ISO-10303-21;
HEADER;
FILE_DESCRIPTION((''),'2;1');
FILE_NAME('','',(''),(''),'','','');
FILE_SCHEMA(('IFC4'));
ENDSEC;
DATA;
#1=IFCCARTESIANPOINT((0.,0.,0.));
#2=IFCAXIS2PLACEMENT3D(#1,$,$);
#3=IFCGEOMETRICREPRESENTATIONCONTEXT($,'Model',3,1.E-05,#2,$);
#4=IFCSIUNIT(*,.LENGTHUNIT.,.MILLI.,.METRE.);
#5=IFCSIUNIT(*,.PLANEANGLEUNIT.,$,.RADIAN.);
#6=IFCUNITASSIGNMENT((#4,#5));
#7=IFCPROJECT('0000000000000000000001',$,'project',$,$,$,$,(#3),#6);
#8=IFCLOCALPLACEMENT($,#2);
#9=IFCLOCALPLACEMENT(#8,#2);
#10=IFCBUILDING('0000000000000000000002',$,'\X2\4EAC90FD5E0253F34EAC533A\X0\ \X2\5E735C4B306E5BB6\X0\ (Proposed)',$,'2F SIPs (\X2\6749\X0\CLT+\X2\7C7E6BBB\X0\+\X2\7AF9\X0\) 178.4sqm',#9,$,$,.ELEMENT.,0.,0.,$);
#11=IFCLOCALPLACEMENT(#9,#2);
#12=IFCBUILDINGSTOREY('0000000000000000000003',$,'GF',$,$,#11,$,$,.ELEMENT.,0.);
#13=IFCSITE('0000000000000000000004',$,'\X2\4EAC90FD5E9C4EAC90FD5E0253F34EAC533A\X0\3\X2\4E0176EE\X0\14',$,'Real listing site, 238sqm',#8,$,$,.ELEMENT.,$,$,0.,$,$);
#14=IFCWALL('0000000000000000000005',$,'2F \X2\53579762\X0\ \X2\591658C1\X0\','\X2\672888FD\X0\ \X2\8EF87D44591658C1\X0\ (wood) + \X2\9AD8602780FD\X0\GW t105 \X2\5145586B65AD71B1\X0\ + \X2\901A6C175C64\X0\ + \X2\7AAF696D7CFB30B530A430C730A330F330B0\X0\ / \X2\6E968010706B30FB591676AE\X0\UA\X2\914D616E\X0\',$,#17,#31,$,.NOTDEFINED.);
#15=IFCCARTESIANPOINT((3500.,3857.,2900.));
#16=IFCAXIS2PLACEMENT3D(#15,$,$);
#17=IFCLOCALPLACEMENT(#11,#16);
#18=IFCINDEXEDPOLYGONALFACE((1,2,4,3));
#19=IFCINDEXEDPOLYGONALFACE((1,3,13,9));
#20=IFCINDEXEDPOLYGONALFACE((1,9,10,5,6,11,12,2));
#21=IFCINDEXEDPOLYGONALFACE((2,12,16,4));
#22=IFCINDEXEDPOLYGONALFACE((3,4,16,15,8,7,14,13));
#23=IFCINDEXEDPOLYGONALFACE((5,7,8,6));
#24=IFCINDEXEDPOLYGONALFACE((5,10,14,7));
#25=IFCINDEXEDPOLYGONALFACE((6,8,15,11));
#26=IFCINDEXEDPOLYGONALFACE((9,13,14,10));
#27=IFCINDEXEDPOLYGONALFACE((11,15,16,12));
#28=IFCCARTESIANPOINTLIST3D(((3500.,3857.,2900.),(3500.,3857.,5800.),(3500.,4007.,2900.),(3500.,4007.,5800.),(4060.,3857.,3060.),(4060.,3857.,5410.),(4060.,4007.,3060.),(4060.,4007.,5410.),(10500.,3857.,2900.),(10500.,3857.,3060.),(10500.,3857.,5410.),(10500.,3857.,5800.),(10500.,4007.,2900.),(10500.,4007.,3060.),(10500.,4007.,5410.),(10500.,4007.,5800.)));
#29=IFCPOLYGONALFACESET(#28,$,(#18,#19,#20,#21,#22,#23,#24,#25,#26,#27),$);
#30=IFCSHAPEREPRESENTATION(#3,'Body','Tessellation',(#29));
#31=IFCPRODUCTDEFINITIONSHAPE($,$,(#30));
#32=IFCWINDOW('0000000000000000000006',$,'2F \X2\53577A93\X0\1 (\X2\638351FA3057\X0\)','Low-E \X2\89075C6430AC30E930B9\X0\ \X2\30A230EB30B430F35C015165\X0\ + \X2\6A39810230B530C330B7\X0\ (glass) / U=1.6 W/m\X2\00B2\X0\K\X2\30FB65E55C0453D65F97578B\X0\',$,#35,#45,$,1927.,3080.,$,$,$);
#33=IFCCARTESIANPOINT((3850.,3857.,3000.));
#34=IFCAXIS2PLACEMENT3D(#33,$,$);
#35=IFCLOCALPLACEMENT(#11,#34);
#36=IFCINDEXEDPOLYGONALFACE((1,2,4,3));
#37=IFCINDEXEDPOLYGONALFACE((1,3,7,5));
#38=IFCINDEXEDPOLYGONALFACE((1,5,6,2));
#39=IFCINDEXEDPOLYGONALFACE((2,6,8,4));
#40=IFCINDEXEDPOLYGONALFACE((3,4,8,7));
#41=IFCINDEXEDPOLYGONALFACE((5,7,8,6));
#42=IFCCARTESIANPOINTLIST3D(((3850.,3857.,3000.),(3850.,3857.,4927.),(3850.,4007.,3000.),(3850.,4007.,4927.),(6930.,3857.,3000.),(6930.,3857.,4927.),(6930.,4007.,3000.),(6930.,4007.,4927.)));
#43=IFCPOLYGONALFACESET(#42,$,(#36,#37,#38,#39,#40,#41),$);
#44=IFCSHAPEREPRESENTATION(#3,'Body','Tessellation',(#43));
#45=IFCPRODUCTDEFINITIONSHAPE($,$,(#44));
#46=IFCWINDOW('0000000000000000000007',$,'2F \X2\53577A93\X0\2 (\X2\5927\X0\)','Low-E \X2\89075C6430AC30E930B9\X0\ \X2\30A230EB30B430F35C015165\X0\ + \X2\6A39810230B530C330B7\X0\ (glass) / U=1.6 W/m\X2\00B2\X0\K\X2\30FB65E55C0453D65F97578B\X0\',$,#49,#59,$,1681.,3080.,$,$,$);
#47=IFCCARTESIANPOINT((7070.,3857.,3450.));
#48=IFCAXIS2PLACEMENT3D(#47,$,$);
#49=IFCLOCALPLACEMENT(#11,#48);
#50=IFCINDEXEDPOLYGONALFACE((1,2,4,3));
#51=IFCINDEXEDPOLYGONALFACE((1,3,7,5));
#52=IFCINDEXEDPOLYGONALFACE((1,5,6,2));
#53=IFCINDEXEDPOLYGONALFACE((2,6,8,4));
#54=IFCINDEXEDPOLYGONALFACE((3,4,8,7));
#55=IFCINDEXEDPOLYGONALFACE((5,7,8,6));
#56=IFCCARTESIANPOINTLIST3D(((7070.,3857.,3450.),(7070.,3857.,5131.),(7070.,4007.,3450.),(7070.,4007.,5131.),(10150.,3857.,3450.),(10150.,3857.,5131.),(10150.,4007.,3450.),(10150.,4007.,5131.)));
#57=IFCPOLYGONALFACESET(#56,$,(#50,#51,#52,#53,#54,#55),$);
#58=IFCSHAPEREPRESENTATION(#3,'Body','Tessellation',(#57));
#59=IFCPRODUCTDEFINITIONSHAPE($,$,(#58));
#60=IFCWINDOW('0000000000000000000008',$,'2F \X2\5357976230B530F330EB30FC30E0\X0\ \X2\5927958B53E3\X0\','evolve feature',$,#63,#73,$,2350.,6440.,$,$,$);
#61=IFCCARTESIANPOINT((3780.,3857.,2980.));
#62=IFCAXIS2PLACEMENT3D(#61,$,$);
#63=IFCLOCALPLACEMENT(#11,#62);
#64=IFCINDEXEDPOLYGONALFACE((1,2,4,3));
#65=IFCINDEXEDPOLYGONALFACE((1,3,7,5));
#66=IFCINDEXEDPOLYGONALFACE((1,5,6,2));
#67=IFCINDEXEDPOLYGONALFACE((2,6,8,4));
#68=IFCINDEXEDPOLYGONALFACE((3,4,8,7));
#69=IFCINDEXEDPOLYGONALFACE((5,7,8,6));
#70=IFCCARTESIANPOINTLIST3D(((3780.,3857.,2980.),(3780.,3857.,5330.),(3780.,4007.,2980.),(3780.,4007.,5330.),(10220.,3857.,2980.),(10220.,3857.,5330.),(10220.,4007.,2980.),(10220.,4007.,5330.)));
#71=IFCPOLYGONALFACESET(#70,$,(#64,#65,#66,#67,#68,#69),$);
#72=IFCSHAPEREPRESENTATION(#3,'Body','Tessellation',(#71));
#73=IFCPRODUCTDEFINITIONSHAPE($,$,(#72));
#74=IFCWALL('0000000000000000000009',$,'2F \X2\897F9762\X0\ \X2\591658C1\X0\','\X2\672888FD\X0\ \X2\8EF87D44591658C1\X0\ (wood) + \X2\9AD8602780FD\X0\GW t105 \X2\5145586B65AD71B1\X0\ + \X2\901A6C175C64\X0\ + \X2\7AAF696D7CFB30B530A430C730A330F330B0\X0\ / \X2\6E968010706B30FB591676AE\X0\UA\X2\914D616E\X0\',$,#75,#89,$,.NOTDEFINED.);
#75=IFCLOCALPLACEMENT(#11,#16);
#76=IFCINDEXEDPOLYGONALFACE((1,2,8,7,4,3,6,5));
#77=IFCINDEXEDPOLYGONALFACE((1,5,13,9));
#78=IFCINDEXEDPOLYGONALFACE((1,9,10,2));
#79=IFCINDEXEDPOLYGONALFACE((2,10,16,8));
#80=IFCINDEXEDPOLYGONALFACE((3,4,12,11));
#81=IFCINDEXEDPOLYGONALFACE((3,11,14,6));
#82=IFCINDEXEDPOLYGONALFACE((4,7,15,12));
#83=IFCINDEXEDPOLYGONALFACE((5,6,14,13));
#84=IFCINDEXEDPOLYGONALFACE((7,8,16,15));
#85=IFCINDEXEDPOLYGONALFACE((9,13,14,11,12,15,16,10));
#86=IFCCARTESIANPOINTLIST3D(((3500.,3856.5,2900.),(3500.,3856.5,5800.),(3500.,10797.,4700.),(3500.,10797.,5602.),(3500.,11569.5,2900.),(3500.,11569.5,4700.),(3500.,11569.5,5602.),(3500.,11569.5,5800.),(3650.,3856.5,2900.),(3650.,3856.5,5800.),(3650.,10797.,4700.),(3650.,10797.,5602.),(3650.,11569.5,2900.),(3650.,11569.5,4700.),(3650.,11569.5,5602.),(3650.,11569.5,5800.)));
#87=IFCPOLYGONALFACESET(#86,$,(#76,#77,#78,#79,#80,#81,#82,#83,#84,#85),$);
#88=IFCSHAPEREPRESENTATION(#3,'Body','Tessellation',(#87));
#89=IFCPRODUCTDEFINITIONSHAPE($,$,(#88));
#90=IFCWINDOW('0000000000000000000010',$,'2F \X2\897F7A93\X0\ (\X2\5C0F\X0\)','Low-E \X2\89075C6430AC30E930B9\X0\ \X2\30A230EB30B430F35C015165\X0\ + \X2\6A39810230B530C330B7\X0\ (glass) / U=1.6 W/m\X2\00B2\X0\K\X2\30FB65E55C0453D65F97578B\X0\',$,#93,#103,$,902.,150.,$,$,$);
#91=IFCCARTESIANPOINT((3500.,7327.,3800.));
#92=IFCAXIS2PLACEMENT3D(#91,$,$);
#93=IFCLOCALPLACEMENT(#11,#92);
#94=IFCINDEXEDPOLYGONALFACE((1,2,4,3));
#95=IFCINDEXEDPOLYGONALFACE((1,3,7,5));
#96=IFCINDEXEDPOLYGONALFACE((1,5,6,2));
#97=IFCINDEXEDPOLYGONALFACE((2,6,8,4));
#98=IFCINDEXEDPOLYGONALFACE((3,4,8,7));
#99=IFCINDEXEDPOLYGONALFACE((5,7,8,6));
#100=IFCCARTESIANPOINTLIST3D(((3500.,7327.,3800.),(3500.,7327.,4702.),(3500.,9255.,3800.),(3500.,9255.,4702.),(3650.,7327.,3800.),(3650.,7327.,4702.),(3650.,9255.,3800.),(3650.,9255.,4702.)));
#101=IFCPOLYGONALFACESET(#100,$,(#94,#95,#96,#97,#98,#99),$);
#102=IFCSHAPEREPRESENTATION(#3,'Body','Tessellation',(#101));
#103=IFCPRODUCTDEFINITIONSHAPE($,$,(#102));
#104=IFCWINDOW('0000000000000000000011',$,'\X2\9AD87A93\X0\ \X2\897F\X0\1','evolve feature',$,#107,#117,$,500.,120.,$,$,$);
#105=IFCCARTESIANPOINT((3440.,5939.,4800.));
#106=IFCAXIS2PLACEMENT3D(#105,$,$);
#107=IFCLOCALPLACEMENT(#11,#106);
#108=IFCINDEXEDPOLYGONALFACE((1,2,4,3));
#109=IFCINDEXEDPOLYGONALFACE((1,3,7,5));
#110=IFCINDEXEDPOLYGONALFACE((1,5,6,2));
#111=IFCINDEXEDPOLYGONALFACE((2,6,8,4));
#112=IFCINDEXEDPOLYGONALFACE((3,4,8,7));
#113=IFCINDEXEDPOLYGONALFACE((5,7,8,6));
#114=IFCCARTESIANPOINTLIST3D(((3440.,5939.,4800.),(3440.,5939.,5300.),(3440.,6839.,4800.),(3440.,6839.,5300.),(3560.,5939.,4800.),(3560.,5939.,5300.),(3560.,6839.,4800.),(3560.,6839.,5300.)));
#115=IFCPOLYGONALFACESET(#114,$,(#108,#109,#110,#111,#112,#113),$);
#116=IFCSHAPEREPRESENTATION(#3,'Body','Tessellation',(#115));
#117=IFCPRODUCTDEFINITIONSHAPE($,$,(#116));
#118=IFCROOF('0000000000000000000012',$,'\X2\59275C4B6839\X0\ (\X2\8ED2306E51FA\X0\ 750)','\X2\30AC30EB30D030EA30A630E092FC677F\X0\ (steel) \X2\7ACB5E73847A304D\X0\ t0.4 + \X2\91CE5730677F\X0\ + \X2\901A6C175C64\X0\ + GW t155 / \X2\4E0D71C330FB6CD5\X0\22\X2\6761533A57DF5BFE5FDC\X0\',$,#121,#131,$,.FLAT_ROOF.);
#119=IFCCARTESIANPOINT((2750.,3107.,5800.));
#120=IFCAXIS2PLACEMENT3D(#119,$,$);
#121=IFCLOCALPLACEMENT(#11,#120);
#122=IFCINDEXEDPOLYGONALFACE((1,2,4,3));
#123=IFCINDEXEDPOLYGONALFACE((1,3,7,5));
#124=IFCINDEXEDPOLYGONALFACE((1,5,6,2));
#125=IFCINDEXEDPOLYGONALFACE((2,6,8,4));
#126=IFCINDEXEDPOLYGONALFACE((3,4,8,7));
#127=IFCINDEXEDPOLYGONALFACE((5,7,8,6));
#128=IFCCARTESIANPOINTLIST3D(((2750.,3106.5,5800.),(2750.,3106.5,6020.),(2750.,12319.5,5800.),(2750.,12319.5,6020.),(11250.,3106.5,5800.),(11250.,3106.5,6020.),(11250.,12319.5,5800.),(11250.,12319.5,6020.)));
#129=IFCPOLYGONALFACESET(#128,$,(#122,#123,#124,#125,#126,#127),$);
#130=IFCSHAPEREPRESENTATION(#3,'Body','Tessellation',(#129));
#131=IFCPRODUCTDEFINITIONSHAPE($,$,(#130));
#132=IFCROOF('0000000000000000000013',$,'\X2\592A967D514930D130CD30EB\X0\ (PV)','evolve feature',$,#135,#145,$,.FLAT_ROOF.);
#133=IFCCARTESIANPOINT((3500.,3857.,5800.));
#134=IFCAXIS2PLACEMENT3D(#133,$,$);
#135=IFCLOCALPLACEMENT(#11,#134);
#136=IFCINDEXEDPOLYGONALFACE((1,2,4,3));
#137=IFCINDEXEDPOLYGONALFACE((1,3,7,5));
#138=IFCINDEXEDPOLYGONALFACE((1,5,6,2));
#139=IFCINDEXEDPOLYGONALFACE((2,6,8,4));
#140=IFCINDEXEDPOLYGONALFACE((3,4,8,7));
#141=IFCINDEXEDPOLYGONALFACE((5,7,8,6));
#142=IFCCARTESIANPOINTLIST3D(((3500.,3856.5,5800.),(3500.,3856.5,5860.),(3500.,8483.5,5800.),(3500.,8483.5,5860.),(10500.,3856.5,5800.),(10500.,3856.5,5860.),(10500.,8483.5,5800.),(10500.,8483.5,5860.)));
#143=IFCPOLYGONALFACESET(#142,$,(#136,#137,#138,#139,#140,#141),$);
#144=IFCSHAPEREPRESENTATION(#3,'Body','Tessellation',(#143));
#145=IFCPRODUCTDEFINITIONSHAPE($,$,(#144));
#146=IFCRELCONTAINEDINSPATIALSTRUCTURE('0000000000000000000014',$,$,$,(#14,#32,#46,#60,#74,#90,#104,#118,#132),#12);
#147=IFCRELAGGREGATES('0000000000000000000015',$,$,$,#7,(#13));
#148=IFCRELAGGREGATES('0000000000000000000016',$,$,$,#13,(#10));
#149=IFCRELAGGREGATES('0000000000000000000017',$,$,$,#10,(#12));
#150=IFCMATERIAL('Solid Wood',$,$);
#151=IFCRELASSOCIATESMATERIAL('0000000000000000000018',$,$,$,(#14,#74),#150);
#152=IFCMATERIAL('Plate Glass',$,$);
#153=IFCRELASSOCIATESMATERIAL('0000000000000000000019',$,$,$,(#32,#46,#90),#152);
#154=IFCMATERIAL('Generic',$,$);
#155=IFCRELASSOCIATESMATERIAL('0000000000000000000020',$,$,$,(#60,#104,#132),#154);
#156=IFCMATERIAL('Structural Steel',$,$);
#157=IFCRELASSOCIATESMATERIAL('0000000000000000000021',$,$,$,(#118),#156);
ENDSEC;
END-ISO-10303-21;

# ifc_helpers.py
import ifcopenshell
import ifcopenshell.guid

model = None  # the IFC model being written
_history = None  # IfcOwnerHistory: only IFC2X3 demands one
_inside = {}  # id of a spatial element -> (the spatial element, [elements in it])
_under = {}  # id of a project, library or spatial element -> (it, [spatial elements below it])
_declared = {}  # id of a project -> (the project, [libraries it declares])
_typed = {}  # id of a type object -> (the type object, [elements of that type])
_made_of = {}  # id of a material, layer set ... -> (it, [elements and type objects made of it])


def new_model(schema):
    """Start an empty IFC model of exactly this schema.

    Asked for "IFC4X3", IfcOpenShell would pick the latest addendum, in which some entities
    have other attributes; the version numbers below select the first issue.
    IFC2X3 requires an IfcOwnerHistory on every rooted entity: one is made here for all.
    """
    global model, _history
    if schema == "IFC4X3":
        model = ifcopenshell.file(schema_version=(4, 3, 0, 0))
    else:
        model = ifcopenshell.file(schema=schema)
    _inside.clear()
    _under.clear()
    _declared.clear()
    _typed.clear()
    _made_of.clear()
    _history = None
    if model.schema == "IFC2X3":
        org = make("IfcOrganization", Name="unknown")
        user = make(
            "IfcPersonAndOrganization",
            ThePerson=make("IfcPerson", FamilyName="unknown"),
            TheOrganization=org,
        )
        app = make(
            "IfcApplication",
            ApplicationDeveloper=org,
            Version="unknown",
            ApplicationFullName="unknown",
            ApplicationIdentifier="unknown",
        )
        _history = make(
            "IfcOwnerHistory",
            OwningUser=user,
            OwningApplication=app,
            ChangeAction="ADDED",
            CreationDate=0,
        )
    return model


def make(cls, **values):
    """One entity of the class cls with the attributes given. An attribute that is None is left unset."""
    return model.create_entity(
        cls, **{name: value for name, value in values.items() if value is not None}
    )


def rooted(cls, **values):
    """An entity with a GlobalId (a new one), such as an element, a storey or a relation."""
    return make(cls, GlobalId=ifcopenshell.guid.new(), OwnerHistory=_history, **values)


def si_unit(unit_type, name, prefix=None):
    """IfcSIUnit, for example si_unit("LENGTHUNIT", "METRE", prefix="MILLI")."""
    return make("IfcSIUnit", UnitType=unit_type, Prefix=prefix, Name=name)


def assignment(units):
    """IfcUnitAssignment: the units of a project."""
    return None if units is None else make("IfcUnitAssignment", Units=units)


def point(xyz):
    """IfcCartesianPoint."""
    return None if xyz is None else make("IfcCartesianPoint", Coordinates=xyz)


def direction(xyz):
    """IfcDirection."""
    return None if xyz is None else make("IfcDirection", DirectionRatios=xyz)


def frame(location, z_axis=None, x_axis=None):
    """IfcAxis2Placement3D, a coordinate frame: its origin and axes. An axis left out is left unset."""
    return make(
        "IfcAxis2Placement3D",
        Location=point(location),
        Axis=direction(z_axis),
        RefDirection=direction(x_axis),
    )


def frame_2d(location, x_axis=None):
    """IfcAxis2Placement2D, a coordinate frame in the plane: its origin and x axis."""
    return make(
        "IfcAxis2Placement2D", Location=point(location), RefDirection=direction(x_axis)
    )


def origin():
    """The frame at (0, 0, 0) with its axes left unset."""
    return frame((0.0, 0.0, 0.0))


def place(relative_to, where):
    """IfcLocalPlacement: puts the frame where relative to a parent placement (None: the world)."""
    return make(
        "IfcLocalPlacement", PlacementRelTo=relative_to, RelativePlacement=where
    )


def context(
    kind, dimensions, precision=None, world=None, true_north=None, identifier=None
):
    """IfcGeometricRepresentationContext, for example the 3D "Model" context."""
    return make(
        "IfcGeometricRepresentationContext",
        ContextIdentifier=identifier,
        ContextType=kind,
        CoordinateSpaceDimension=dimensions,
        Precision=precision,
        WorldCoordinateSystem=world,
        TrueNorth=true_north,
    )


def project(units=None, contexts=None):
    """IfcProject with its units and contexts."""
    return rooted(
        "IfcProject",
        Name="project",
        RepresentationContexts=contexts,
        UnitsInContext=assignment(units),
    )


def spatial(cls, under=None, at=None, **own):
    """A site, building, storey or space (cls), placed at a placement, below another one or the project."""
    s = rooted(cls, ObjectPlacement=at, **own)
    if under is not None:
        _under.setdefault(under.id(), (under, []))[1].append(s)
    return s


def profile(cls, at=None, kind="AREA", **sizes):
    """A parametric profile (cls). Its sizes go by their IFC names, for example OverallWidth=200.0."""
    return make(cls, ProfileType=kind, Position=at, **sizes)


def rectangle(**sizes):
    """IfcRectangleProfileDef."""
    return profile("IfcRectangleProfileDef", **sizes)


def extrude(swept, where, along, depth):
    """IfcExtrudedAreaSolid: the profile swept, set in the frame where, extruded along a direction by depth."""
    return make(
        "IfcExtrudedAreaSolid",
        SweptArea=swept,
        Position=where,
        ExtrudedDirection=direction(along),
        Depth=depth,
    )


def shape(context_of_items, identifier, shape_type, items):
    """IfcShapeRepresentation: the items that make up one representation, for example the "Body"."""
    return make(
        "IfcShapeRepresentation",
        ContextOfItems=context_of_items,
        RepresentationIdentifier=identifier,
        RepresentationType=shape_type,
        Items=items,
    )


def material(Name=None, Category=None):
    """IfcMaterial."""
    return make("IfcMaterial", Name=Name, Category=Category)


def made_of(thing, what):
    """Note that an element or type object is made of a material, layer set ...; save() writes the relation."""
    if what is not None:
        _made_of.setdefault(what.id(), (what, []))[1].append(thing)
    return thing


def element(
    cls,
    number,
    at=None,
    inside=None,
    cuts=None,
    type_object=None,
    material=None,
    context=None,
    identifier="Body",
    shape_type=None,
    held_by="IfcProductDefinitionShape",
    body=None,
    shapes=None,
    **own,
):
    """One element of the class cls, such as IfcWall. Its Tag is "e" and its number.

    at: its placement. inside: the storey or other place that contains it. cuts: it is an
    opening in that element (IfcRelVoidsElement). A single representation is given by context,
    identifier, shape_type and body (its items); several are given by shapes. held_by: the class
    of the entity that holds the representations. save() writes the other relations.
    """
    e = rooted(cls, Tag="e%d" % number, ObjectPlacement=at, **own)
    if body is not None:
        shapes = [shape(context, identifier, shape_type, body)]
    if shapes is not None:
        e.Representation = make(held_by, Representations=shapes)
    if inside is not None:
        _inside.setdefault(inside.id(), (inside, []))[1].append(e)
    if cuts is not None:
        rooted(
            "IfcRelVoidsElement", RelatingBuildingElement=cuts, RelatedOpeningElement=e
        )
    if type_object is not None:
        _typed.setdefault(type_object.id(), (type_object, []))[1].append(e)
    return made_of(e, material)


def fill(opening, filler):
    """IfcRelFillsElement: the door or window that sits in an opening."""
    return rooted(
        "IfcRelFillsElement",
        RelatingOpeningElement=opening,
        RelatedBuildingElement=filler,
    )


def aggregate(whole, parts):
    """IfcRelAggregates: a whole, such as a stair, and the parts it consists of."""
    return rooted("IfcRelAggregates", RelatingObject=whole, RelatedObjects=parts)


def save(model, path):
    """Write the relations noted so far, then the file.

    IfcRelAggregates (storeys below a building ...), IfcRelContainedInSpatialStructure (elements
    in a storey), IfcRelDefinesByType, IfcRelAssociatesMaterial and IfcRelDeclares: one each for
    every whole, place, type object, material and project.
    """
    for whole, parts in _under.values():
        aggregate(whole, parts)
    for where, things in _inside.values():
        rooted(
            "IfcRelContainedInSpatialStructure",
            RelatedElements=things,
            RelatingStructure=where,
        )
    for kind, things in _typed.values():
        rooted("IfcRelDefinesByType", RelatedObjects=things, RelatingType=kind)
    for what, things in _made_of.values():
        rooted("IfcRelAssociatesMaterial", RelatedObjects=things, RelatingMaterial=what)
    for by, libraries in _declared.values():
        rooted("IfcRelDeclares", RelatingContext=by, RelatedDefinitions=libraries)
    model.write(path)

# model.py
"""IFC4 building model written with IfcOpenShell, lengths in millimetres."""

from ifc_helpers import new_model, si_unit, frame, frame_2d, origin, place, context, project, spatial, rectangle, extrude, material, element, fill, save


model = new_model("IFC4")

# Units and contexts
model_context = context("Model", 3, precision=1e-05, world=origin())
ifc_project = project(units=[si_unit("LENGTHUNIT", "METRE", prefix="MILLI"), si_unit("PLANEANGLEUNIT", "RADIAN")], contexts=[model_context])

# Site, building, storey
site_placement = place(None, origin())
site = spatial("IfcSite", under=ifc_project, at=site_placement, Name="京都府京都市右京区3丁目14", ObjectType="Real listing site, 238sqm", CompositionType="ELEMENT", RefElevation=0.0)
building_placement = place(site_placement, origin())
building = spatial("IfcBuilding", under=site, at=building_placement, Name="京都市右京区 平屋の家 (Proposed)", ObjectType="2F SIPs (杉CLT+籾殻+竹) 178.4sqm", CompositionType="ELEMENT", ElevationOfRefHeight=0.0, ElevationOfTerrain=0.0)
storey_placement = place(building_placement, origin())
storey = spatial("IfcBuildingStorey", under=building, at=storey_placement, Name="GF", CompositionType="ELEMENT", Elevation=0.0)

# Shared definitions
ifc_material_1 = material(Name="Solid Wood")
ifc_material_2 = material(Name="Generic")

# Shared definitions
ifc_material_3 = material(Name="Plate Glass")

# Walls, openings, windows
wall_1_placement = place(storey_placement, frame((3500.0, 3857.0, 2900.0)))
wall_1 = element("IfcWall", 1, at=wall_1_placement, inside=storey, material=ifc_material_1, Name="2F 南面 外壁", Description="木製 軸組外壁 (wood) + 高性能GW t105 充填断熱 + 通気層 + 窯業系サイディング / 準耐火・外皮UA配慮", PredefinedType="NOTDEFINED", context=model_context, shape_type="SweptSolid", body=[
    extrude(rectangle(XDim=7000.0, YDim=150.0, at=frame_2d((3500.0, 75.0))), frame((3500.0, 3857.0, 2900.0)), (0.0, 0.0, 1.0), 2900.0),
])
opening_1_placement = place(storey_placement, frame((3850.0, 3857.0, 3000.0)))
opening_1 = element("IfcOpeningElement", 2, at=opening_1_placement, cuts=wall_1, PredefinedType="NOTDEFINED", context=model_context, shape_type="SweptSolid", body=[
    extrude(rectangle(XDim=3080.0, YDim=150.0, at=frame_2d((1540.0, 75.0))), frame((3850.0, 3857.0, 3000.0)), (0.0, 0.0, 1.0), 1927.0),
])
opening_2_placement = place(storey_placement, frame((7070.0, 3857.0, 3450.0)))
opening_2 = element("IfcOpeningElement", 3, at=opening_2_placement, cuts=wall_1, PredefinedType="NOTDEFINED", context=model_context, shape_type="SweptSolid", body=[
    extrude(rectangle(XDim=3080.0, YDim=150.0, at=frame_2d((1540.0, 75.0))), frame((7070.0, 3857.0, 3450.0)), (0.0, 0.0, 1.0), 1681.0),
])
opening_3_placement = place(storey_placement, frame((3780.0, 3857.0, 2980.0)))
opening_3 = element("IfcOpeningElement", 4, at=opening_3_placement, cuts=wall_1, PredefinedType="NOTDEFINED", context=model_context, shape_type="SweptSolid", body=[
    extrude(rectangle(XDim=6440.0, YDim=150.0, at=frame_2d((3220.0, 75.0))), frame((3780.0, 3857.0, 2980.0)), (0.0, 0.0, 1.0), 2350.0),
])
window_1_placement = place(storey_placement, frame((3850.0, 3857.0, 3000.0)))
window_1 = element("IfcWindow", 5, at=window_1_placement, inside=storey, material=ifc_material_3, Name="2F 南窓1 (掃出し)", Description="Low-E 複層ガラス アルゴン封入 + 樹脂サッシ (glass) / U=1.6 W/m²K・日射取得型", OverallHeight=1927.0, OverallWidth=3080.0, context=model_context, shape_type="SweptSolid", body=[
    extrude(rectangle(XDim=3080.0, YDim=150.0, at=frame_2d((1540.0, 75.0))), frame((3850.0, 3857.0, 3000.0)), (0.0, 0.0, 1.0), 1927.0),
])
fill(opening_1, window_1)
window_2_placement = place(storey_placement, frame((7070.0, 3857.0, 3450.0)))
window_2 = element("IfcWindow", 6, at=window_2_placement, inside=storey, material=ifc_material_3, Name="2F 南窓2 (大)", Description="Low-E 複層ガラス アルゴン封入 + 樹脂サッシ (glass) / U=1.6 W/m²K・日射取得型", OverallHeight=1681.0, OverallWidth=3080.0, context=model_context, shape_type="SweptSolid", body=[
    extrude(rectangle(XDim=3080.0, YDim=150.0, at=frame_2d((1540.0, 75.0))), frame((7070.0, 3857.0, 3450.0)), (0.0, 0.0, 1.0), 1681.0),
])
fill(opening_2, window_2)
window_3_placement = place(storey_placement, frame((3780.0, 3857.0, 2980.0)))
window_3 = element("IfcWindow", 7, at=window_3_placement, inside=storey, material=ifc_material_2, Name="2F 南面サンルーム 大開口", Description="evolve feature", OverallHeight=2350.0, OverallWidth=6440.0, context=model_context, shape_type="SweptSolid", body=[
    extrude(rectangle(XDim=6440.0, YDim=150.0, at=frame_2d((3220.0, 75.0))), frame((3780.0, 3857.0, 2980.0)), (0.0, 0.0, 1.0), 2350.0),
])
fill(opening_3, window_3)
wall_2_placement = place(storey_placement, frame((3500.0, 3857.0, 2900.0)))
wall_2 = element("IfcWall", 8, at=wall_2_placement, inside=storey, material=ifc_material_1, Name="2F 西面 外壁", Description="木製 軸組外壁 (wood) + 高性能GW t105 充填断熱 + 通気層 + 窯業系サイディング / 準耐火・外皮UA配慮", PredefinedType="NOTDEFINED", context=model_context, shape_type="SweptSolid", body=[
    extrude(rectangle(XDim=150.0, YDim=7713.0, at=frame_2d((75.0, 3856.0))), frame((3500.0, 3857.0, 2900.0)), (0.0, 0.0, 1.0), 2900.0),
])
opening_4_placement = place(storey_placement, frame((3500.0, 7327.0, 3800.0)))
opening_4 = element("IfcOpeningElement", 9, at=opening_4_placement, cuts=wall_2, PredefinedType="NOTDEFINED", context=model_context, shape_type="SweptSolid", body=[
    extrude(rectangle(XDim=150.0, YDim=1928.0, at=frame_2d((75.0, 964.0))), frame((3500.0, 7327.0, 3800.0)), (0.0, 0.0, 1.0), 902.0),
])
opening_5_placement = place(storey_placement, frame((3440.0, 5939.0, 4800.0)))
opening_5 = element("IfcOpeningElement", 10, at=opening_5_placement, cuts=wall_2, PredefinedType="NOTDEFINED", context=model_context, shape_type="SweptSolid", body=[
    extrude(rectangle(XDim=120.0, YDim=900.0, at=frame_2d((60.0, 450.0))), frame((3440.0, 5939.0, 4800.0)), (0.0, 0.0, 1.0), 500.0),
])
window_4_placement = place(storey_placement, frame((3500.0, 7327.0, 3800.0)))
window_4 = element("IfcWindow", 11, at=window_4_placement, inside=storey, material=ifc_material_3, Name="2F 西窓 (小)", Description="Low-E 複層ガラス アルゴン封入 + 樹脂サッシ (glass) / U=1.6 W/m²K・日射取得型", OverallHeight=902.0, OverallWidth=150.0, context=model_context, shape_type="SweptSolid", body=[
    extrude(rectangle(XDim=150.0, YDim=1928.0, at=frame_2d((75.0, 964.0))), frame((3500.0, 7327.0, 3800.0)), (0.0, 0.0, 1.0), 902.0),
])
fill(opening_4, window_4)
window_5_placement = place(storey_placement, frame((3440.0, 5939.0, 4800.0)))
window_5 = element("IfcWindow", 12, at=window_5_placement, inside=storey, material=ifc_material_2, Name="高窓 西1", Description="evolve feature", OverallHeight=500.0, OverallWidth=120.0, context=model_context, shape_type="SweptSolid", body=[
    extrude(rectangle(XDim=120.0, YDim=900.0, at=frame_2d((60.0, 450.0))), frame((3440.0, 5939.0, 4800.0)), (0.0, 0.0, 1.0), 500.0),
])
fill(opening_5, window_5)

# Roofs
ifc_material_4 = material(Name="Structural Steel")
roof_1_placement = place(storey_placement, frame((2750.0, 3107.0, 5800.0)))
element("IfcRoof", 13, at=roof_1_placement, inside=storey, material=ifc_material_4, Name="大屋根 (軒の出 750)", Description="ガルバリウム鋼板 (steel) 立平葺き t0.4 + 野地板 + 通気層 + GW t155 / 不燃・法22条区域対応", PredefinedType="FLAT_ROOF", context=model_context, shape_type="SweptSolid", body=[
    extrude(rectangle(XDim=8500.0, YDim=9213.0, at=frame_2d((4250.0, 4606.0))), frame((2750.0, 3107.0, 5800.0)), (0.0, 0.0, 1.0), 220.0),
])
roof_2_placement = place(storey_placement, frame((3500.0, 3857.0, 5800.0)))
element("IfcRoof", 14, at=roof_2_placement, inside=storey, material=ifc_material_2, Name="太陽光パネル (PV)", Description="evolve feature", PredefinedType="FLAT_ROOF", context=model_context, shape_type="SweptSolid", body=[
    extrude(rectangle(XDim=7000.0, YDim=4627.0, at=frame_2d((3500.0, 2313.0))), frame((3500.0, 3857.0, 5800.0)), (0.0, 0.0, 1.0), 60.0),
])

save(model, "model.ifc")
